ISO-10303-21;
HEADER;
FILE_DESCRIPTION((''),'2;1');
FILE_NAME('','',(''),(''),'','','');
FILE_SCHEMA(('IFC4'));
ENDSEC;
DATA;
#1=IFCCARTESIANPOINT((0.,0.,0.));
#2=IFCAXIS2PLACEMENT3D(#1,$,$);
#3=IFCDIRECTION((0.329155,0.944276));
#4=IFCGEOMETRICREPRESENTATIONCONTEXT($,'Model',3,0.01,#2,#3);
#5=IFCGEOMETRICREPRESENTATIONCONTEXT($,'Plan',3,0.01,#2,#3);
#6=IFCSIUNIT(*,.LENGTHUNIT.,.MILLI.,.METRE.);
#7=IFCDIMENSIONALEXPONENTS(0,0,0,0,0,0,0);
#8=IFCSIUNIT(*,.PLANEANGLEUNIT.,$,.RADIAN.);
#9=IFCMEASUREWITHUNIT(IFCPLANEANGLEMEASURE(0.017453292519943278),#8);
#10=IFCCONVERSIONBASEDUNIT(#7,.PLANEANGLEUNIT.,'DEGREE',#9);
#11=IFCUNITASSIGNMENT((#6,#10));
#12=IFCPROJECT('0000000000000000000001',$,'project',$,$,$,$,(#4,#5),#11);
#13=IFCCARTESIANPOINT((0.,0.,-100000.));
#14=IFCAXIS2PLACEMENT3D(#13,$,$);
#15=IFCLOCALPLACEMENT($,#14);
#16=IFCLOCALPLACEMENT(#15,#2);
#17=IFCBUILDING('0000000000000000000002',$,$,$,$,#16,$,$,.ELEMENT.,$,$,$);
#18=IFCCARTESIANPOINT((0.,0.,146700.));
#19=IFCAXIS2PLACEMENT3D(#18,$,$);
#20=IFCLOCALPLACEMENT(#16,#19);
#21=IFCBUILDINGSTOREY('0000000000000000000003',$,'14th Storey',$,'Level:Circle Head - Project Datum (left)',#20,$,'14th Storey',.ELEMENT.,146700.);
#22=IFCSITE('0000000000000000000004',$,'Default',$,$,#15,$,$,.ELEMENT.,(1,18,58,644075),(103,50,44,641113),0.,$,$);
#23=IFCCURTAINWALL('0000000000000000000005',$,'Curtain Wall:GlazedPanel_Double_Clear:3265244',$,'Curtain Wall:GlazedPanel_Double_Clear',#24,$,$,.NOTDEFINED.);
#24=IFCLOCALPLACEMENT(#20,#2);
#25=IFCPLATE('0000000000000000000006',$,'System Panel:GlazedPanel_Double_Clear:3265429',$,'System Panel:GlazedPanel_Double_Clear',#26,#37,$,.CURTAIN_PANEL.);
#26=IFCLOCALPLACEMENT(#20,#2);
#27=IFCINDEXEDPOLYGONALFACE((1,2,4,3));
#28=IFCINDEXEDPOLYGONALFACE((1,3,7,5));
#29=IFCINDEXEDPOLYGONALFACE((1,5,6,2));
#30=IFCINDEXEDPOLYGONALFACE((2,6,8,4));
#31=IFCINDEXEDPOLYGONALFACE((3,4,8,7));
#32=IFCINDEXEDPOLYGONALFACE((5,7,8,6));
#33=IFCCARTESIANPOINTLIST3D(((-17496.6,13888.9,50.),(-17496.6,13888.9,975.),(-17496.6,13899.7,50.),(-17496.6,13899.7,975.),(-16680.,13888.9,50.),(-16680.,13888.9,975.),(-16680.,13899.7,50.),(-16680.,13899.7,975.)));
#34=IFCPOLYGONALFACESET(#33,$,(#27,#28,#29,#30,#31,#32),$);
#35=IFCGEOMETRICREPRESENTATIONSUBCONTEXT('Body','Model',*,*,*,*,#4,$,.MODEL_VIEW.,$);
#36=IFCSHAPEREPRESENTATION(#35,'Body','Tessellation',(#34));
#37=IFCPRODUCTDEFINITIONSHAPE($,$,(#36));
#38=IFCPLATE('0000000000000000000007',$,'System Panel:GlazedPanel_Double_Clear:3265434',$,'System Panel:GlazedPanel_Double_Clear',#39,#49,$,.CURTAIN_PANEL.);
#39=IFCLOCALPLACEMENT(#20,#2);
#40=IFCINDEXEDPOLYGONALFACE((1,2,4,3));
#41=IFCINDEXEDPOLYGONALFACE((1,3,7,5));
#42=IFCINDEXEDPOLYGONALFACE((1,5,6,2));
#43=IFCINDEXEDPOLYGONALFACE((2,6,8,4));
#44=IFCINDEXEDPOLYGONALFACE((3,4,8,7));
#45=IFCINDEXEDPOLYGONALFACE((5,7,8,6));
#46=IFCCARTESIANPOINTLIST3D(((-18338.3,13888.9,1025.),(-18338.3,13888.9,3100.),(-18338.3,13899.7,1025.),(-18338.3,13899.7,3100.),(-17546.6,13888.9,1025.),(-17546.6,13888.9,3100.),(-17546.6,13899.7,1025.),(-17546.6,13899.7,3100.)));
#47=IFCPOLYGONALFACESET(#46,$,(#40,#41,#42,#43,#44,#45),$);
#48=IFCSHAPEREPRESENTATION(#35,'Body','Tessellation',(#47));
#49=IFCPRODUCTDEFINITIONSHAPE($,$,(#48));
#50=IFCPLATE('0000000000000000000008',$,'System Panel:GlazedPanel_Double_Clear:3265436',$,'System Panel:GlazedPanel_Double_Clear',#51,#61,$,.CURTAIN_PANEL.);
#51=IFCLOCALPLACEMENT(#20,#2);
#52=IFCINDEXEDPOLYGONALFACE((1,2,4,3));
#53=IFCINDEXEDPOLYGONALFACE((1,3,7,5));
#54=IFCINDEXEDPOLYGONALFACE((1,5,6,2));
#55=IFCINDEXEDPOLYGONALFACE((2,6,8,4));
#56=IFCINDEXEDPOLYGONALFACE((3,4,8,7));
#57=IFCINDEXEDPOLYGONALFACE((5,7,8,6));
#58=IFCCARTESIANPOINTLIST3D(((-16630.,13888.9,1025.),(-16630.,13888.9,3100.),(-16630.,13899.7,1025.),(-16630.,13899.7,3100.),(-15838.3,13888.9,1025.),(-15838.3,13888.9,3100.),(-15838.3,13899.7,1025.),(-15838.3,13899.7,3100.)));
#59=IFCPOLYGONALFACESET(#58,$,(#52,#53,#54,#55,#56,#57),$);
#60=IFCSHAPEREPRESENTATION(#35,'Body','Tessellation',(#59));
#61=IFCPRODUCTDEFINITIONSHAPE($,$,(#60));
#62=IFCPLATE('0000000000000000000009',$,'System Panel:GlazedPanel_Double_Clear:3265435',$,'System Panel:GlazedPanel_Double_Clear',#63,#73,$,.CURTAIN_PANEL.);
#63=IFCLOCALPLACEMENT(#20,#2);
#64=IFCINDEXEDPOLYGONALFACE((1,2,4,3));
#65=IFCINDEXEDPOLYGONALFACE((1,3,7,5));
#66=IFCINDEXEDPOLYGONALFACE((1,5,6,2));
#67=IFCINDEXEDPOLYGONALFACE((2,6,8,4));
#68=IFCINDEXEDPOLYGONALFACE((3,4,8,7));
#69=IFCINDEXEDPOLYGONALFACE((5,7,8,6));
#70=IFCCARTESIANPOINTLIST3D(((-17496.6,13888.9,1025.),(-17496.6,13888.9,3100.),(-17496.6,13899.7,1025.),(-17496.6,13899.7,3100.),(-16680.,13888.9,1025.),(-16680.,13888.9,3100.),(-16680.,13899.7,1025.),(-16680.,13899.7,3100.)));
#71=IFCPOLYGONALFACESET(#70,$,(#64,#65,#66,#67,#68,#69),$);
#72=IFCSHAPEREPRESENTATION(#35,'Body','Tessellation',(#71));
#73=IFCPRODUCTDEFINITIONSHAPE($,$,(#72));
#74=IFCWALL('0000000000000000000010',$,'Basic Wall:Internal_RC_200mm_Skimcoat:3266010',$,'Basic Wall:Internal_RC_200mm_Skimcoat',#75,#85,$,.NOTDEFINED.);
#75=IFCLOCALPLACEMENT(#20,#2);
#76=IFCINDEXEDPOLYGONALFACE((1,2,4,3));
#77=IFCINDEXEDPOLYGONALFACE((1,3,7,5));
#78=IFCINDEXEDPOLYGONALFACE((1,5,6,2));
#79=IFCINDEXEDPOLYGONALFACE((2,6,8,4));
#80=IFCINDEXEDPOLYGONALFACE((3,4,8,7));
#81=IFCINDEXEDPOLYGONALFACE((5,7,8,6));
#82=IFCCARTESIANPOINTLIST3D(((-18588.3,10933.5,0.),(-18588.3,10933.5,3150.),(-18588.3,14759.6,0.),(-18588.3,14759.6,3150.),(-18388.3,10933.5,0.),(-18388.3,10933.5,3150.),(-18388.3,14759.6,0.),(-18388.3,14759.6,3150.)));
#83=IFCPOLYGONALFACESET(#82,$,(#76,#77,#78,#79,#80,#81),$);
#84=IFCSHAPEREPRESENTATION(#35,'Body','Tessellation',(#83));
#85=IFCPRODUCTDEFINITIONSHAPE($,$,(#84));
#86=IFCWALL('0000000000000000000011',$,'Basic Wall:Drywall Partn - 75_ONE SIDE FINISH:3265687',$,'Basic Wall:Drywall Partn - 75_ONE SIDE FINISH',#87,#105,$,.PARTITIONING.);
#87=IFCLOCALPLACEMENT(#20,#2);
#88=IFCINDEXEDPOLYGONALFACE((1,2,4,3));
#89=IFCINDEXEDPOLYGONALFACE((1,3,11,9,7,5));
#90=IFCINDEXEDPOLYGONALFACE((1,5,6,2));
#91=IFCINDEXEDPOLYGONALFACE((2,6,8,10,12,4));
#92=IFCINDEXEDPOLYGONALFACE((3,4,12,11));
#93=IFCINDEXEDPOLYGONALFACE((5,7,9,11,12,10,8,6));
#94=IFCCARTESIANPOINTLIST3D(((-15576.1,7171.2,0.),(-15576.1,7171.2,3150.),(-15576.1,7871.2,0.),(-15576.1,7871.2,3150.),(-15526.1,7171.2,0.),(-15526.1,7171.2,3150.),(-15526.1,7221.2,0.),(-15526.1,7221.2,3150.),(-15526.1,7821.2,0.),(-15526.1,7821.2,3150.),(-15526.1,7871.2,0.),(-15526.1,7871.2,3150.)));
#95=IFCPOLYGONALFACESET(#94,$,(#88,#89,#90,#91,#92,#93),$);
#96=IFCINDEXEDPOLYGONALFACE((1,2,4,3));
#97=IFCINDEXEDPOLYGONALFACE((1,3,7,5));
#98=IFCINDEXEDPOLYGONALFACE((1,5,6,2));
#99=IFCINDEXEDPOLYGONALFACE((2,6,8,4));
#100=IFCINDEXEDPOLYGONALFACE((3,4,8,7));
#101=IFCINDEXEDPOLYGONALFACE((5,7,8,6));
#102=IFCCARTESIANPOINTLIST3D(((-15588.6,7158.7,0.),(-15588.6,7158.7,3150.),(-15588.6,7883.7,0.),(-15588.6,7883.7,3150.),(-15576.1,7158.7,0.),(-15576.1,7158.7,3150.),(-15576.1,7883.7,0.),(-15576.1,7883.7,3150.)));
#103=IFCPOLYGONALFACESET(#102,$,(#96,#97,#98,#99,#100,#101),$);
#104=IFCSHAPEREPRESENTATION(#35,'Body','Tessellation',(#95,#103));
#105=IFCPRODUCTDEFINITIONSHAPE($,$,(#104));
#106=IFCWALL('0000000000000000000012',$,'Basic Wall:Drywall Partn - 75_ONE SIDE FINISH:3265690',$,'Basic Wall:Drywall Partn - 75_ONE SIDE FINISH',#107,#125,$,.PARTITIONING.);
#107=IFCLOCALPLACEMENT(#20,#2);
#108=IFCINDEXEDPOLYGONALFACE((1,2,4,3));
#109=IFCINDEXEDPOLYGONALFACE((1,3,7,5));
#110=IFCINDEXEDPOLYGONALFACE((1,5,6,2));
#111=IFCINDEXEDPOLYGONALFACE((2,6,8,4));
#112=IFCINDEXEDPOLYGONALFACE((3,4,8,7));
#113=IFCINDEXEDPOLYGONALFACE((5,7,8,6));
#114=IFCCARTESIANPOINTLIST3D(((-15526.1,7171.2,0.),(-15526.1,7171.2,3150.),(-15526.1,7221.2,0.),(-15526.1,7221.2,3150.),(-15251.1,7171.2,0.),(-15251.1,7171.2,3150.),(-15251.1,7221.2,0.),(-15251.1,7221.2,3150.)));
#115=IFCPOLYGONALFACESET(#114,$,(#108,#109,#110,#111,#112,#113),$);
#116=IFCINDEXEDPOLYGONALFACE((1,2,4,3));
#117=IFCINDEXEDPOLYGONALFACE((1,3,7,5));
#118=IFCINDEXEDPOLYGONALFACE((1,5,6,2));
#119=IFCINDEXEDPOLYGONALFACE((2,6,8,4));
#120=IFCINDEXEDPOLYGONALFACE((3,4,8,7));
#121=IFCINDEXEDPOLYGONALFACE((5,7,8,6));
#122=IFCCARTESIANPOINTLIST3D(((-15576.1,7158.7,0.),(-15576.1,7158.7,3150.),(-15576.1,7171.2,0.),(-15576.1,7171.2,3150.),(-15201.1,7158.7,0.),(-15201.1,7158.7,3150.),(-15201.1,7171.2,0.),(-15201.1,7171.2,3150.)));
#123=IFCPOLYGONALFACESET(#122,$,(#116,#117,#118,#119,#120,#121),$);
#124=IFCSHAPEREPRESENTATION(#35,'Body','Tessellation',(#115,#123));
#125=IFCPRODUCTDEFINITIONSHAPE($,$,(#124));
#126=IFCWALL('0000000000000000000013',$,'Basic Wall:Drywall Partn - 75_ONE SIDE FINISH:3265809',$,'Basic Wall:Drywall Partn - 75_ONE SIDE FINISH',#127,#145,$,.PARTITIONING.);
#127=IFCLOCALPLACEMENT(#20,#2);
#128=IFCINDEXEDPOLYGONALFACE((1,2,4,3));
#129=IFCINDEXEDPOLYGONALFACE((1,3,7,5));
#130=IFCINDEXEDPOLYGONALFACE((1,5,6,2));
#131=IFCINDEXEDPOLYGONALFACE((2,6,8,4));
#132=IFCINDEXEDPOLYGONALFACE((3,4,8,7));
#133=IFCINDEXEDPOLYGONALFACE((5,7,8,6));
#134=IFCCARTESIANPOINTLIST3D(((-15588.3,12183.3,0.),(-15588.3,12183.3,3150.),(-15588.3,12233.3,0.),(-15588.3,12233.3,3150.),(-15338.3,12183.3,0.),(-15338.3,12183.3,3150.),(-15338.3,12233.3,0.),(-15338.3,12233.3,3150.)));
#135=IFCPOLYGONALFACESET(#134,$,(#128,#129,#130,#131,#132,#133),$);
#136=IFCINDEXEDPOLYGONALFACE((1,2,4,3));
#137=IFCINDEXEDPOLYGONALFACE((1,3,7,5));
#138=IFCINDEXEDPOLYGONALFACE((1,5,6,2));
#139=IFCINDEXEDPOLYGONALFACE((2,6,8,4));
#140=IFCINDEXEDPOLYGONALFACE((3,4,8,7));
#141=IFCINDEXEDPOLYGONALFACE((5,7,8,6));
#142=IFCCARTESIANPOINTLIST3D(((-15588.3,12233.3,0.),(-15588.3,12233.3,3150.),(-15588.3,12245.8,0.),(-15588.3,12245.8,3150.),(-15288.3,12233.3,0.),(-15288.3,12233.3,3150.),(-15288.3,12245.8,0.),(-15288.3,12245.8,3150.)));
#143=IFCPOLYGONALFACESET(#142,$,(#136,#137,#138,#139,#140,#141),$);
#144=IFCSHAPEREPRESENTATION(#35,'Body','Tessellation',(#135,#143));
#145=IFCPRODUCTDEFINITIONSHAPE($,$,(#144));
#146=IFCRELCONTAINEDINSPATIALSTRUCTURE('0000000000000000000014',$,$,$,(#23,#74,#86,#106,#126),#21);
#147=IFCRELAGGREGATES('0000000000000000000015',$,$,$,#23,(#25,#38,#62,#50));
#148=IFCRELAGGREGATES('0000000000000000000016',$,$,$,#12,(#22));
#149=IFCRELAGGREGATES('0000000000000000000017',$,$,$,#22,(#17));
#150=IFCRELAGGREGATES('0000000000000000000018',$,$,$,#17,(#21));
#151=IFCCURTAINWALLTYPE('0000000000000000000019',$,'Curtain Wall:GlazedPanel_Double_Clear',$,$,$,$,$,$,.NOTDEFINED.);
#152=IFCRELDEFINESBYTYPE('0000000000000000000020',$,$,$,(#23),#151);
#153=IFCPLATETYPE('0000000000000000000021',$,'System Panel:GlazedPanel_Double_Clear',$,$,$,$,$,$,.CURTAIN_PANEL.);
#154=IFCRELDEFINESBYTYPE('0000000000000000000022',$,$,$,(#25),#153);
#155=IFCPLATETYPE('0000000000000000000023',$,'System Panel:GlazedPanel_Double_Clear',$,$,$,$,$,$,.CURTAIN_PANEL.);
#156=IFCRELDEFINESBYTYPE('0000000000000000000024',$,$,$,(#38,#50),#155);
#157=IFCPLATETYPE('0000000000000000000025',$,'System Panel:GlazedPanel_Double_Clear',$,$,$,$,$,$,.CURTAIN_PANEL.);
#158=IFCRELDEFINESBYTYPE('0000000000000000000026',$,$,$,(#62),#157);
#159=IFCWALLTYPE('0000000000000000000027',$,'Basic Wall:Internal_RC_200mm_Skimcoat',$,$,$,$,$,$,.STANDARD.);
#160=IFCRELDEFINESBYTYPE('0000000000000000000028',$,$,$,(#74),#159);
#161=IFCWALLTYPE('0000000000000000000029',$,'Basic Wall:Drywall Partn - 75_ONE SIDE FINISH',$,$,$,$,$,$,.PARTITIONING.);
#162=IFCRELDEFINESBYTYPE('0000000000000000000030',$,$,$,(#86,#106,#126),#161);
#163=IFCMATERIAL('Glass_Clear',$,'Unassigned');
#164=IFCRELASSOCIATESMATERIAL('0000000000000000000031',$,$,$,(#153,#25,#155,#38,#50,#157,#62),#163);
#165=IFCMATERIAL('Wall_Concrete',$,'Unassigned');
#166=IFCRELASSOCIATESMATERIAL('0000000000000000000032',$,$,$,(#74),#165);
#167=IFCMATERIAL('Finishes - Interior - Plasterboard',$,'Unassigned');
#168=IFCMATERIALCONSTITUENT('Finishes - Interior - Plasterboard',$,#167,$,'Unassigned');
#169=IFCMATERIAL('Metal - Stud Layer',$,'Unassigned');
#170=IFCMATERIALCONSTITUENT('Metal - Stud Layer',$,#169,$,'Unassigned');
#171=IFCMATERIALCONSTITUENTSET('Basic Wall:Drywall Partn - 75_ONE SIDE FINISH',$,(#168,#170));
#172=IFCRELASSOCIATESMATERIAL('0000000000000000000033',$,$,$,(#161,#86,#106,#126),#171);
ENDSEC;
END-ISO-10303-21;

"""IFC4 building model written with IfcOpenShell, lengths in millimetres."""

from ifc_helpers import new_model, entity, si_unit, converted_unit, direction, frame, origin, place, context, subcontext, project, spatial, indexed_curve, outline, extrude, source, transform, mapped, material, constituent, constituent_set, type_object, type_shapes, element, aggregate, save


model = new_model("IFC4")

# Units and contexts
model_context = context("Model", 3, precision=0.01, world=origin(), true_north=direction((0.329155, 0.944276)))
plan_context = context("Plan", 3, precision=0.01, world=origin(), true_north=direction((0.329155, 0.944276)))
body_context = subcontext(model_context, "Body", "Model", "MODEL_VIEW")
ifc_project = project(units=[si_unit("LENGTHUNIT", "METRE", prefix="MILLI"), converted_unit("PLANEANGLEUNIT", "DEGREE", entity("IfcPlaneAngleMeasure", 0.017453292519943278), si_unit("PLANEANGLEUNIT", "RADIAN"), dimensions=[0, 0, 0, 0, 0, 0, 0])], contexts=[model_context, plan_context])

# Site, building, storey
site_placement = place(None, frame((0.0, 0.0, -100000.0)))
site = spatial("IfcSite", under=ifc_project, at=site_placement, Name="Default", CompositionType="ELEMENT", RefLatitude=(1, 18, 58, 644075), RefLongitude=(103, 50, 44, 641113), RefElevation=0.0)
building_placement = place(site_placement, origin())
building = spatial("IfcBuilding", under=site, at=building_placement, CompositionType="ELEMENT")
storey_placement = place(building_placement, frame((0.0, 0.0, 146700.0)))
storey = spatial("IfcBuildingStorey", under=building, at=storey_placement, Name="14th Storey", ObjectType="Level:Circle Head - Project Datum (left)", LongName="14th Storey", CompositionType="ELEMENT", Elevation=146700.0)

# Shared definitions
curtain_wall_type = type_object("IfcCurtainWallType", Name="Curtain Wall:GlazedPanel_Double_Clear", PredefinedType="NOTDEFINED")

# Curtain wall
curtain_wall_1_placement = place(storey_placement, frame((0.0, 0.0, -146700.0)))
curtain_wall_1 = element("IfcCurtainWall", 1, at=curtain_wall_1_placement, inside=storey, type_object=curtain_wall_type, Name="Curtain Wall:GlazedPanel_Double_Clear:3265244", ObjectType="Curtain Wall:GlazedPanel_Double_Clear", PredefinedType="NOTDEFINED")

# Plates
ifc_material_1 = material(Name="Glass_Clear", Category="Unassigned")
plate_type_1 = type_object("IfcPlateType", Name="System Panel:GlazedPanel_Double_Clear", PredefinedType="CURTAIN_PANEL", material=ifc_material_1)
shared_shape_1 = source(origin(), body_context, "Body", "SweptSolid", [
    extrude(outline(indexed_curve([(-5.4, -408.3), (5.4, -408.3), (5.4, 408.3), (-5.4, 408.3), (-5.4, -408.3)], self_intersect=False)), frame((408.3, 5.4, 0.0), z_axis=(0.0, 0.0, 1.0), x_axis=(0.0, 1.0, 0.0)), (0.0, 0.0, 1.0), 925.0),
])
type_shapes(plate_type_1, [shared_shape_1])
plate_1_placement = place(curtain_wall_1_placement, frame((-17496.6, 13888.9, 146750.0)))
plate_1 = element("IfcPlate", 2, at=plate_1_placement, type_object=plate_type_1, material=ifc_material_1, Name="System Panel:GlazedPanel_Double_Clear:3265429", ObjectType="System Panel:GlazedPanel_Double_Clear", PredefinedType="CURTAIN_PANEL", context=body_context, shape_type="MappedRepresentation", body=[
    mapped(shared_shape_1, transform((0.0, 0.0, 0.0), scale=1.0)),
])
plate_type_2 = type_object("IfcPlateType", Name="System Panel:GlazedPanel_Double_Clear", PredefinedType="CURTAIN_PANEL", material=ifc_material_1)
shared_shape_2 = source(origin(), body_context, "Body", "SweptSolid", [
    extrude(outline(indexed_curve([(-5.4, -395.8), (5.4, -395.8), (5.4, 395.8), (-5.4, 395.8), (-5.4, -395.8)], self_intersect=False)), frame((395.8, 5.4, 0.0), z_axis=(0.0, 0.0, 1.0), x_axis=(0.0, 1.0, 0.0)), (0.0, 0.0, 1.0), 2075.0),
])
type_shapes(plate_type_2, [shared_shape_2])
plate_2_placement = place(curtain_wall_1_placement, frame((-18338.3, 13888.9, 147725.0)))
plate_2 = element("IfcPlate", 3, at=plate_2_placement, type_object=plate_type_2, material=ifc_material_1, Name="System Panel:GlazedPanel_Double_Clear:3265434", ObjectType="System Panel:GlazedPanel_Double_Clear", PredefinedType="CURTAIN_PANEL", context=body_context, shape_type="MappedRepresentation", body=[
    mapped(shared_shape_2, transform((0.0, 0.0, 0.0), scale=1.0)),
])
plate_3_placement = place(curtain_wall_1_placement, frame((-16630.0, 13888.9, 147725.0)))
plate_3 = element("IfcPlate", 4, at=plate_3_placement, type_object=plate_type_2, material=ifc_material_1, Name="System Panel:GlazedPanel_Double_Clear:3265436", ObjectType="System Panel:GlazedPanel_Double_Clear", PredefinedType="CURTAIN_PANEL", context=body_context, shape_type="MappedRepresentation", body=[
    mapped(shared_shape_2, transform((0.0, 0.0, 0.0), scale=1.0)),
])
plate_type_3 = type_object("IfcPlateType", Name="System Panel:GlazedPanel_Double_Clear", PredefinedType="CURTAIN_PANEL", material=ifc_material_1)
shared_shape_3 = source(origin(), body_context, "Body", "SweptSolid", [
    extrude(outline(indexed_curve([(-5.4, -408.3), (5.4, -408.3), (5.4, 408.3), (-5.4, 408.3), (-5.4, -408.3)], self_intersect=False)), frame((408.3, 5.4, 0.0), z_axis=(0.0, 0.0, 1.0), x_axis=(0.0, 1.0, 0.0)), (0.0, 0.0, 1.0), 2075.0),
])
type_shapes(plate_type_3, [shared_shape_3])
plate_4_placement = place(curtain_wall_1_placement, frame((-17496.6, 13888.9, 147725.0)))
plate_4 = element("IfcPlate", 5, at=plate_4_placement, type_object=plate_type_3, material=ifc_material_1, Name="System Panel:GlazedPanel_Double_Clear:3265435", ObjectType="System Panel:GlazedPanel_Double_Clear", PredefinedType="CURTAIN_PANEL", context=body_context, shape_type="MappedRepresentation", body=[
    mapped(shared_shape_3, transform((0.0, 0.0, 0.0), scale=1.0)),
])
aggregate(curtain_wall_1, [plate_1, plate_2, plate_4, plate_3])

# Walls
ifc_material_2 = material(Name="Wall_Concrete", Category="Unassigned")
wall_type_1 = type_object("IfcWallType", Name="Basic Wall:Internal_RC_200mm_Skimcoat", PredefinedType="STANDARD")
wall_1_placement = place(storey_placement, frame((-18488.3, 14759.6, 0.0), z_axis=(0.0, 0.0, 1.0), x_axis=(0.0, -1.0, 0.0)))
element("IfcWall", 6, at=wall_1_placement, inside=storey, type_object=wall_type_1, material=ifc_material_2, Name="Basic Wall:Internal_RC_200mm_Skimcoat:3266010", ObjectType="Basic Wall:Internal_RC_200mm_Skimcoat", PredefinedType="NOTDEFINED", context=body_context, shape_type="SweptSolid", body=[
    extrude(outline(indexed_curve([(3826.2, 100.0), (0.0, 100.0), (0.0, -100.0), (3826.2, -100.0), (3826.2, 100.0)], self_intersect=False)), origin(), (0.0, 0.0, 1.0), 3150.0),
])
ifc_material_3 = material(Name="Finishes - Interior - Plasterboard", Category="Unassigned")
ifc_constituent_1 = constituent(ifc_material_3, Name="Finishes - Interior - Plasterboard", Category="Unassigned")
ifc_material_4 = material(Name="Metal - Stud Layer", Category="Unassigned")
ifc_constituent_2 = constituent(ifc_material_4, Name="Metal - Stud Layer", Category="Unassigned")
ifc_constituent_set = constituent_set(constituents=[ifc_constituent_1, ifc_constituent_2], Name="Basic Wall:Drywall Partn - 75_ONE SIDE FINISH")
wall_type_2 = type_object("IfcWallType", Name="Basic Wall:Drywall Partn - 75_ONE SIDE FINISH", PredefinedType="PARTITIONING", material=ifc_constituent_set)
wall_2_placement = place(storey_placement, frame((-15557.3, 7158.7, 0.0), z_axis=(0.0, 0.0, 1.0), x_axis=(0.0, 1.0, 0.0)))
element("IfcWall", 7, at=wall_2_placement, inside=storey, type_object=wall_type_2, material=ifc_constituent_set, Name="Basic Wall:Drywall Partn - 75_ONE SIDE FINISH:3265687", ObjectType="Basic Wall:Drywall Partn - 75_ONE SIDE FINISH", PredefinedType="PARTITIONING", context=body_context, shape_type="SweptSolid", body=[
    extrude(outline(indexed_curve([(-300.0, -16.7), (300.0, -16.7), (350.0, -16.7), (350.0, 33.3), (-350.0, 33.3), (-350.0, -16.7), (-300.0, -16.7)], self_intersect=False)), frame((362.5, -14.6, 0.0)), (0.0, 0.0, 1.0), 3150.0),
    extrude(outline(indexed_curve([(-6.3, -362.5), (6.2, -362.5), (6.2, 362.5), (-6.3, 362.5), (-6.3, -362.5)], self_intersect=False)), frame((362.5, 25.0, 0.0), z_axis=(0.0, 0.0, 1.0), x_axis=(0.0, -1.0, 0.0)), (0.0, 0.0, 1.0), 3150.0),
])
wall_3_placement = place(storey_placement, frame((-15526.1, 7189.9, 0.0)))
element("IfcWall", 8, at=wall_3_placement, inside=storey, type_object=wall_type_2, material=ifc_constituent_set, Name="Basic Wall:Drywall Partn - 75_ONE SIDE FINISH:3265690", ObjectType="Basic Wall:Drywall Partn - 75_ONE SIDE FINISH", PredefinedType="PARTITIONING", context=body_context, shape_type="SweptSolid", body=[
    extrude(outline(indexed_curve([(-25.0, -137.5), (25.0, -137.5), (25.0, 137.5), (-25.0, 137.5), (-25.0, -137.5)], self_intersect=False)), frame((137.5, 6.3, 0.0), z_axis=(0.0, 0.0, 1.0), x_axis=(0.0, -1.0, 0.0)), (0.0, 0.0, 1.0), 3150.0),
    extrude(outline(indexed_curve([(-6.3, -187.5), (6.2, -187.5), (6.3, 187.5), (-6.2, 187.5), (-6.3, -187.5)], self_intersect=False)), frame((137.5, -25.0, 0.0), z_axis=(0.0, 0.0, 1.0), x_axis=(0.0, 1.0, 0.0)), (0.0, 0.0, 1.0), 3150.0),
])
wall_4_placement = place(storey_placement, frame((-15338.3, 12214.5, 0.0), z_axis=(0.0, 0.0, 1.0), x_axis=(-1.0, 0.0, 0.0)))
element("IfcWall", 9, at=wall_4_placement, inside=storey, type_object=wall_type_2, material=ifc_constituent_set, Name="Basic Wall:Drywall Partn - 75_ONE SIDE FINISH:3265809", ObjectType="Basic Wall:Drywall Partn - 75_ONE SIDE FINISH", PredefinedType="PARTITIONING", context=body_context, shape_type="SweptSolid", body=[
    extrude(outline(indexed_curve([(-25.0, -125.0), (25.0, -125.0), (25.0, 125.0), (-25.0, 125.0), (-25.0, -125.0)], self_intersect=False)), frame((125.0, 6.2, 0.0), z_axis=(0.0, 0.0, 1.0), x_axis=(0.0, -1.0, 0.0)), (0.0, 0.0, 1.0), 3150.0),
    extrude(outline(indexed_curve([(-6.3, -150.0), (6.3, -150.0), (6.3, 150.0), (-6.3, 150.0), (-6.3, -150.0)], self_intersect=False)), frame((100.0, -25.0, 0.0), z_axis=(0.0, 0.0, 1.0), x_axis=(0.0, 1.0, 0.0)), (0.0, 0.0, 1.0), 3150.0),
])

save(model, "model.ifc")
